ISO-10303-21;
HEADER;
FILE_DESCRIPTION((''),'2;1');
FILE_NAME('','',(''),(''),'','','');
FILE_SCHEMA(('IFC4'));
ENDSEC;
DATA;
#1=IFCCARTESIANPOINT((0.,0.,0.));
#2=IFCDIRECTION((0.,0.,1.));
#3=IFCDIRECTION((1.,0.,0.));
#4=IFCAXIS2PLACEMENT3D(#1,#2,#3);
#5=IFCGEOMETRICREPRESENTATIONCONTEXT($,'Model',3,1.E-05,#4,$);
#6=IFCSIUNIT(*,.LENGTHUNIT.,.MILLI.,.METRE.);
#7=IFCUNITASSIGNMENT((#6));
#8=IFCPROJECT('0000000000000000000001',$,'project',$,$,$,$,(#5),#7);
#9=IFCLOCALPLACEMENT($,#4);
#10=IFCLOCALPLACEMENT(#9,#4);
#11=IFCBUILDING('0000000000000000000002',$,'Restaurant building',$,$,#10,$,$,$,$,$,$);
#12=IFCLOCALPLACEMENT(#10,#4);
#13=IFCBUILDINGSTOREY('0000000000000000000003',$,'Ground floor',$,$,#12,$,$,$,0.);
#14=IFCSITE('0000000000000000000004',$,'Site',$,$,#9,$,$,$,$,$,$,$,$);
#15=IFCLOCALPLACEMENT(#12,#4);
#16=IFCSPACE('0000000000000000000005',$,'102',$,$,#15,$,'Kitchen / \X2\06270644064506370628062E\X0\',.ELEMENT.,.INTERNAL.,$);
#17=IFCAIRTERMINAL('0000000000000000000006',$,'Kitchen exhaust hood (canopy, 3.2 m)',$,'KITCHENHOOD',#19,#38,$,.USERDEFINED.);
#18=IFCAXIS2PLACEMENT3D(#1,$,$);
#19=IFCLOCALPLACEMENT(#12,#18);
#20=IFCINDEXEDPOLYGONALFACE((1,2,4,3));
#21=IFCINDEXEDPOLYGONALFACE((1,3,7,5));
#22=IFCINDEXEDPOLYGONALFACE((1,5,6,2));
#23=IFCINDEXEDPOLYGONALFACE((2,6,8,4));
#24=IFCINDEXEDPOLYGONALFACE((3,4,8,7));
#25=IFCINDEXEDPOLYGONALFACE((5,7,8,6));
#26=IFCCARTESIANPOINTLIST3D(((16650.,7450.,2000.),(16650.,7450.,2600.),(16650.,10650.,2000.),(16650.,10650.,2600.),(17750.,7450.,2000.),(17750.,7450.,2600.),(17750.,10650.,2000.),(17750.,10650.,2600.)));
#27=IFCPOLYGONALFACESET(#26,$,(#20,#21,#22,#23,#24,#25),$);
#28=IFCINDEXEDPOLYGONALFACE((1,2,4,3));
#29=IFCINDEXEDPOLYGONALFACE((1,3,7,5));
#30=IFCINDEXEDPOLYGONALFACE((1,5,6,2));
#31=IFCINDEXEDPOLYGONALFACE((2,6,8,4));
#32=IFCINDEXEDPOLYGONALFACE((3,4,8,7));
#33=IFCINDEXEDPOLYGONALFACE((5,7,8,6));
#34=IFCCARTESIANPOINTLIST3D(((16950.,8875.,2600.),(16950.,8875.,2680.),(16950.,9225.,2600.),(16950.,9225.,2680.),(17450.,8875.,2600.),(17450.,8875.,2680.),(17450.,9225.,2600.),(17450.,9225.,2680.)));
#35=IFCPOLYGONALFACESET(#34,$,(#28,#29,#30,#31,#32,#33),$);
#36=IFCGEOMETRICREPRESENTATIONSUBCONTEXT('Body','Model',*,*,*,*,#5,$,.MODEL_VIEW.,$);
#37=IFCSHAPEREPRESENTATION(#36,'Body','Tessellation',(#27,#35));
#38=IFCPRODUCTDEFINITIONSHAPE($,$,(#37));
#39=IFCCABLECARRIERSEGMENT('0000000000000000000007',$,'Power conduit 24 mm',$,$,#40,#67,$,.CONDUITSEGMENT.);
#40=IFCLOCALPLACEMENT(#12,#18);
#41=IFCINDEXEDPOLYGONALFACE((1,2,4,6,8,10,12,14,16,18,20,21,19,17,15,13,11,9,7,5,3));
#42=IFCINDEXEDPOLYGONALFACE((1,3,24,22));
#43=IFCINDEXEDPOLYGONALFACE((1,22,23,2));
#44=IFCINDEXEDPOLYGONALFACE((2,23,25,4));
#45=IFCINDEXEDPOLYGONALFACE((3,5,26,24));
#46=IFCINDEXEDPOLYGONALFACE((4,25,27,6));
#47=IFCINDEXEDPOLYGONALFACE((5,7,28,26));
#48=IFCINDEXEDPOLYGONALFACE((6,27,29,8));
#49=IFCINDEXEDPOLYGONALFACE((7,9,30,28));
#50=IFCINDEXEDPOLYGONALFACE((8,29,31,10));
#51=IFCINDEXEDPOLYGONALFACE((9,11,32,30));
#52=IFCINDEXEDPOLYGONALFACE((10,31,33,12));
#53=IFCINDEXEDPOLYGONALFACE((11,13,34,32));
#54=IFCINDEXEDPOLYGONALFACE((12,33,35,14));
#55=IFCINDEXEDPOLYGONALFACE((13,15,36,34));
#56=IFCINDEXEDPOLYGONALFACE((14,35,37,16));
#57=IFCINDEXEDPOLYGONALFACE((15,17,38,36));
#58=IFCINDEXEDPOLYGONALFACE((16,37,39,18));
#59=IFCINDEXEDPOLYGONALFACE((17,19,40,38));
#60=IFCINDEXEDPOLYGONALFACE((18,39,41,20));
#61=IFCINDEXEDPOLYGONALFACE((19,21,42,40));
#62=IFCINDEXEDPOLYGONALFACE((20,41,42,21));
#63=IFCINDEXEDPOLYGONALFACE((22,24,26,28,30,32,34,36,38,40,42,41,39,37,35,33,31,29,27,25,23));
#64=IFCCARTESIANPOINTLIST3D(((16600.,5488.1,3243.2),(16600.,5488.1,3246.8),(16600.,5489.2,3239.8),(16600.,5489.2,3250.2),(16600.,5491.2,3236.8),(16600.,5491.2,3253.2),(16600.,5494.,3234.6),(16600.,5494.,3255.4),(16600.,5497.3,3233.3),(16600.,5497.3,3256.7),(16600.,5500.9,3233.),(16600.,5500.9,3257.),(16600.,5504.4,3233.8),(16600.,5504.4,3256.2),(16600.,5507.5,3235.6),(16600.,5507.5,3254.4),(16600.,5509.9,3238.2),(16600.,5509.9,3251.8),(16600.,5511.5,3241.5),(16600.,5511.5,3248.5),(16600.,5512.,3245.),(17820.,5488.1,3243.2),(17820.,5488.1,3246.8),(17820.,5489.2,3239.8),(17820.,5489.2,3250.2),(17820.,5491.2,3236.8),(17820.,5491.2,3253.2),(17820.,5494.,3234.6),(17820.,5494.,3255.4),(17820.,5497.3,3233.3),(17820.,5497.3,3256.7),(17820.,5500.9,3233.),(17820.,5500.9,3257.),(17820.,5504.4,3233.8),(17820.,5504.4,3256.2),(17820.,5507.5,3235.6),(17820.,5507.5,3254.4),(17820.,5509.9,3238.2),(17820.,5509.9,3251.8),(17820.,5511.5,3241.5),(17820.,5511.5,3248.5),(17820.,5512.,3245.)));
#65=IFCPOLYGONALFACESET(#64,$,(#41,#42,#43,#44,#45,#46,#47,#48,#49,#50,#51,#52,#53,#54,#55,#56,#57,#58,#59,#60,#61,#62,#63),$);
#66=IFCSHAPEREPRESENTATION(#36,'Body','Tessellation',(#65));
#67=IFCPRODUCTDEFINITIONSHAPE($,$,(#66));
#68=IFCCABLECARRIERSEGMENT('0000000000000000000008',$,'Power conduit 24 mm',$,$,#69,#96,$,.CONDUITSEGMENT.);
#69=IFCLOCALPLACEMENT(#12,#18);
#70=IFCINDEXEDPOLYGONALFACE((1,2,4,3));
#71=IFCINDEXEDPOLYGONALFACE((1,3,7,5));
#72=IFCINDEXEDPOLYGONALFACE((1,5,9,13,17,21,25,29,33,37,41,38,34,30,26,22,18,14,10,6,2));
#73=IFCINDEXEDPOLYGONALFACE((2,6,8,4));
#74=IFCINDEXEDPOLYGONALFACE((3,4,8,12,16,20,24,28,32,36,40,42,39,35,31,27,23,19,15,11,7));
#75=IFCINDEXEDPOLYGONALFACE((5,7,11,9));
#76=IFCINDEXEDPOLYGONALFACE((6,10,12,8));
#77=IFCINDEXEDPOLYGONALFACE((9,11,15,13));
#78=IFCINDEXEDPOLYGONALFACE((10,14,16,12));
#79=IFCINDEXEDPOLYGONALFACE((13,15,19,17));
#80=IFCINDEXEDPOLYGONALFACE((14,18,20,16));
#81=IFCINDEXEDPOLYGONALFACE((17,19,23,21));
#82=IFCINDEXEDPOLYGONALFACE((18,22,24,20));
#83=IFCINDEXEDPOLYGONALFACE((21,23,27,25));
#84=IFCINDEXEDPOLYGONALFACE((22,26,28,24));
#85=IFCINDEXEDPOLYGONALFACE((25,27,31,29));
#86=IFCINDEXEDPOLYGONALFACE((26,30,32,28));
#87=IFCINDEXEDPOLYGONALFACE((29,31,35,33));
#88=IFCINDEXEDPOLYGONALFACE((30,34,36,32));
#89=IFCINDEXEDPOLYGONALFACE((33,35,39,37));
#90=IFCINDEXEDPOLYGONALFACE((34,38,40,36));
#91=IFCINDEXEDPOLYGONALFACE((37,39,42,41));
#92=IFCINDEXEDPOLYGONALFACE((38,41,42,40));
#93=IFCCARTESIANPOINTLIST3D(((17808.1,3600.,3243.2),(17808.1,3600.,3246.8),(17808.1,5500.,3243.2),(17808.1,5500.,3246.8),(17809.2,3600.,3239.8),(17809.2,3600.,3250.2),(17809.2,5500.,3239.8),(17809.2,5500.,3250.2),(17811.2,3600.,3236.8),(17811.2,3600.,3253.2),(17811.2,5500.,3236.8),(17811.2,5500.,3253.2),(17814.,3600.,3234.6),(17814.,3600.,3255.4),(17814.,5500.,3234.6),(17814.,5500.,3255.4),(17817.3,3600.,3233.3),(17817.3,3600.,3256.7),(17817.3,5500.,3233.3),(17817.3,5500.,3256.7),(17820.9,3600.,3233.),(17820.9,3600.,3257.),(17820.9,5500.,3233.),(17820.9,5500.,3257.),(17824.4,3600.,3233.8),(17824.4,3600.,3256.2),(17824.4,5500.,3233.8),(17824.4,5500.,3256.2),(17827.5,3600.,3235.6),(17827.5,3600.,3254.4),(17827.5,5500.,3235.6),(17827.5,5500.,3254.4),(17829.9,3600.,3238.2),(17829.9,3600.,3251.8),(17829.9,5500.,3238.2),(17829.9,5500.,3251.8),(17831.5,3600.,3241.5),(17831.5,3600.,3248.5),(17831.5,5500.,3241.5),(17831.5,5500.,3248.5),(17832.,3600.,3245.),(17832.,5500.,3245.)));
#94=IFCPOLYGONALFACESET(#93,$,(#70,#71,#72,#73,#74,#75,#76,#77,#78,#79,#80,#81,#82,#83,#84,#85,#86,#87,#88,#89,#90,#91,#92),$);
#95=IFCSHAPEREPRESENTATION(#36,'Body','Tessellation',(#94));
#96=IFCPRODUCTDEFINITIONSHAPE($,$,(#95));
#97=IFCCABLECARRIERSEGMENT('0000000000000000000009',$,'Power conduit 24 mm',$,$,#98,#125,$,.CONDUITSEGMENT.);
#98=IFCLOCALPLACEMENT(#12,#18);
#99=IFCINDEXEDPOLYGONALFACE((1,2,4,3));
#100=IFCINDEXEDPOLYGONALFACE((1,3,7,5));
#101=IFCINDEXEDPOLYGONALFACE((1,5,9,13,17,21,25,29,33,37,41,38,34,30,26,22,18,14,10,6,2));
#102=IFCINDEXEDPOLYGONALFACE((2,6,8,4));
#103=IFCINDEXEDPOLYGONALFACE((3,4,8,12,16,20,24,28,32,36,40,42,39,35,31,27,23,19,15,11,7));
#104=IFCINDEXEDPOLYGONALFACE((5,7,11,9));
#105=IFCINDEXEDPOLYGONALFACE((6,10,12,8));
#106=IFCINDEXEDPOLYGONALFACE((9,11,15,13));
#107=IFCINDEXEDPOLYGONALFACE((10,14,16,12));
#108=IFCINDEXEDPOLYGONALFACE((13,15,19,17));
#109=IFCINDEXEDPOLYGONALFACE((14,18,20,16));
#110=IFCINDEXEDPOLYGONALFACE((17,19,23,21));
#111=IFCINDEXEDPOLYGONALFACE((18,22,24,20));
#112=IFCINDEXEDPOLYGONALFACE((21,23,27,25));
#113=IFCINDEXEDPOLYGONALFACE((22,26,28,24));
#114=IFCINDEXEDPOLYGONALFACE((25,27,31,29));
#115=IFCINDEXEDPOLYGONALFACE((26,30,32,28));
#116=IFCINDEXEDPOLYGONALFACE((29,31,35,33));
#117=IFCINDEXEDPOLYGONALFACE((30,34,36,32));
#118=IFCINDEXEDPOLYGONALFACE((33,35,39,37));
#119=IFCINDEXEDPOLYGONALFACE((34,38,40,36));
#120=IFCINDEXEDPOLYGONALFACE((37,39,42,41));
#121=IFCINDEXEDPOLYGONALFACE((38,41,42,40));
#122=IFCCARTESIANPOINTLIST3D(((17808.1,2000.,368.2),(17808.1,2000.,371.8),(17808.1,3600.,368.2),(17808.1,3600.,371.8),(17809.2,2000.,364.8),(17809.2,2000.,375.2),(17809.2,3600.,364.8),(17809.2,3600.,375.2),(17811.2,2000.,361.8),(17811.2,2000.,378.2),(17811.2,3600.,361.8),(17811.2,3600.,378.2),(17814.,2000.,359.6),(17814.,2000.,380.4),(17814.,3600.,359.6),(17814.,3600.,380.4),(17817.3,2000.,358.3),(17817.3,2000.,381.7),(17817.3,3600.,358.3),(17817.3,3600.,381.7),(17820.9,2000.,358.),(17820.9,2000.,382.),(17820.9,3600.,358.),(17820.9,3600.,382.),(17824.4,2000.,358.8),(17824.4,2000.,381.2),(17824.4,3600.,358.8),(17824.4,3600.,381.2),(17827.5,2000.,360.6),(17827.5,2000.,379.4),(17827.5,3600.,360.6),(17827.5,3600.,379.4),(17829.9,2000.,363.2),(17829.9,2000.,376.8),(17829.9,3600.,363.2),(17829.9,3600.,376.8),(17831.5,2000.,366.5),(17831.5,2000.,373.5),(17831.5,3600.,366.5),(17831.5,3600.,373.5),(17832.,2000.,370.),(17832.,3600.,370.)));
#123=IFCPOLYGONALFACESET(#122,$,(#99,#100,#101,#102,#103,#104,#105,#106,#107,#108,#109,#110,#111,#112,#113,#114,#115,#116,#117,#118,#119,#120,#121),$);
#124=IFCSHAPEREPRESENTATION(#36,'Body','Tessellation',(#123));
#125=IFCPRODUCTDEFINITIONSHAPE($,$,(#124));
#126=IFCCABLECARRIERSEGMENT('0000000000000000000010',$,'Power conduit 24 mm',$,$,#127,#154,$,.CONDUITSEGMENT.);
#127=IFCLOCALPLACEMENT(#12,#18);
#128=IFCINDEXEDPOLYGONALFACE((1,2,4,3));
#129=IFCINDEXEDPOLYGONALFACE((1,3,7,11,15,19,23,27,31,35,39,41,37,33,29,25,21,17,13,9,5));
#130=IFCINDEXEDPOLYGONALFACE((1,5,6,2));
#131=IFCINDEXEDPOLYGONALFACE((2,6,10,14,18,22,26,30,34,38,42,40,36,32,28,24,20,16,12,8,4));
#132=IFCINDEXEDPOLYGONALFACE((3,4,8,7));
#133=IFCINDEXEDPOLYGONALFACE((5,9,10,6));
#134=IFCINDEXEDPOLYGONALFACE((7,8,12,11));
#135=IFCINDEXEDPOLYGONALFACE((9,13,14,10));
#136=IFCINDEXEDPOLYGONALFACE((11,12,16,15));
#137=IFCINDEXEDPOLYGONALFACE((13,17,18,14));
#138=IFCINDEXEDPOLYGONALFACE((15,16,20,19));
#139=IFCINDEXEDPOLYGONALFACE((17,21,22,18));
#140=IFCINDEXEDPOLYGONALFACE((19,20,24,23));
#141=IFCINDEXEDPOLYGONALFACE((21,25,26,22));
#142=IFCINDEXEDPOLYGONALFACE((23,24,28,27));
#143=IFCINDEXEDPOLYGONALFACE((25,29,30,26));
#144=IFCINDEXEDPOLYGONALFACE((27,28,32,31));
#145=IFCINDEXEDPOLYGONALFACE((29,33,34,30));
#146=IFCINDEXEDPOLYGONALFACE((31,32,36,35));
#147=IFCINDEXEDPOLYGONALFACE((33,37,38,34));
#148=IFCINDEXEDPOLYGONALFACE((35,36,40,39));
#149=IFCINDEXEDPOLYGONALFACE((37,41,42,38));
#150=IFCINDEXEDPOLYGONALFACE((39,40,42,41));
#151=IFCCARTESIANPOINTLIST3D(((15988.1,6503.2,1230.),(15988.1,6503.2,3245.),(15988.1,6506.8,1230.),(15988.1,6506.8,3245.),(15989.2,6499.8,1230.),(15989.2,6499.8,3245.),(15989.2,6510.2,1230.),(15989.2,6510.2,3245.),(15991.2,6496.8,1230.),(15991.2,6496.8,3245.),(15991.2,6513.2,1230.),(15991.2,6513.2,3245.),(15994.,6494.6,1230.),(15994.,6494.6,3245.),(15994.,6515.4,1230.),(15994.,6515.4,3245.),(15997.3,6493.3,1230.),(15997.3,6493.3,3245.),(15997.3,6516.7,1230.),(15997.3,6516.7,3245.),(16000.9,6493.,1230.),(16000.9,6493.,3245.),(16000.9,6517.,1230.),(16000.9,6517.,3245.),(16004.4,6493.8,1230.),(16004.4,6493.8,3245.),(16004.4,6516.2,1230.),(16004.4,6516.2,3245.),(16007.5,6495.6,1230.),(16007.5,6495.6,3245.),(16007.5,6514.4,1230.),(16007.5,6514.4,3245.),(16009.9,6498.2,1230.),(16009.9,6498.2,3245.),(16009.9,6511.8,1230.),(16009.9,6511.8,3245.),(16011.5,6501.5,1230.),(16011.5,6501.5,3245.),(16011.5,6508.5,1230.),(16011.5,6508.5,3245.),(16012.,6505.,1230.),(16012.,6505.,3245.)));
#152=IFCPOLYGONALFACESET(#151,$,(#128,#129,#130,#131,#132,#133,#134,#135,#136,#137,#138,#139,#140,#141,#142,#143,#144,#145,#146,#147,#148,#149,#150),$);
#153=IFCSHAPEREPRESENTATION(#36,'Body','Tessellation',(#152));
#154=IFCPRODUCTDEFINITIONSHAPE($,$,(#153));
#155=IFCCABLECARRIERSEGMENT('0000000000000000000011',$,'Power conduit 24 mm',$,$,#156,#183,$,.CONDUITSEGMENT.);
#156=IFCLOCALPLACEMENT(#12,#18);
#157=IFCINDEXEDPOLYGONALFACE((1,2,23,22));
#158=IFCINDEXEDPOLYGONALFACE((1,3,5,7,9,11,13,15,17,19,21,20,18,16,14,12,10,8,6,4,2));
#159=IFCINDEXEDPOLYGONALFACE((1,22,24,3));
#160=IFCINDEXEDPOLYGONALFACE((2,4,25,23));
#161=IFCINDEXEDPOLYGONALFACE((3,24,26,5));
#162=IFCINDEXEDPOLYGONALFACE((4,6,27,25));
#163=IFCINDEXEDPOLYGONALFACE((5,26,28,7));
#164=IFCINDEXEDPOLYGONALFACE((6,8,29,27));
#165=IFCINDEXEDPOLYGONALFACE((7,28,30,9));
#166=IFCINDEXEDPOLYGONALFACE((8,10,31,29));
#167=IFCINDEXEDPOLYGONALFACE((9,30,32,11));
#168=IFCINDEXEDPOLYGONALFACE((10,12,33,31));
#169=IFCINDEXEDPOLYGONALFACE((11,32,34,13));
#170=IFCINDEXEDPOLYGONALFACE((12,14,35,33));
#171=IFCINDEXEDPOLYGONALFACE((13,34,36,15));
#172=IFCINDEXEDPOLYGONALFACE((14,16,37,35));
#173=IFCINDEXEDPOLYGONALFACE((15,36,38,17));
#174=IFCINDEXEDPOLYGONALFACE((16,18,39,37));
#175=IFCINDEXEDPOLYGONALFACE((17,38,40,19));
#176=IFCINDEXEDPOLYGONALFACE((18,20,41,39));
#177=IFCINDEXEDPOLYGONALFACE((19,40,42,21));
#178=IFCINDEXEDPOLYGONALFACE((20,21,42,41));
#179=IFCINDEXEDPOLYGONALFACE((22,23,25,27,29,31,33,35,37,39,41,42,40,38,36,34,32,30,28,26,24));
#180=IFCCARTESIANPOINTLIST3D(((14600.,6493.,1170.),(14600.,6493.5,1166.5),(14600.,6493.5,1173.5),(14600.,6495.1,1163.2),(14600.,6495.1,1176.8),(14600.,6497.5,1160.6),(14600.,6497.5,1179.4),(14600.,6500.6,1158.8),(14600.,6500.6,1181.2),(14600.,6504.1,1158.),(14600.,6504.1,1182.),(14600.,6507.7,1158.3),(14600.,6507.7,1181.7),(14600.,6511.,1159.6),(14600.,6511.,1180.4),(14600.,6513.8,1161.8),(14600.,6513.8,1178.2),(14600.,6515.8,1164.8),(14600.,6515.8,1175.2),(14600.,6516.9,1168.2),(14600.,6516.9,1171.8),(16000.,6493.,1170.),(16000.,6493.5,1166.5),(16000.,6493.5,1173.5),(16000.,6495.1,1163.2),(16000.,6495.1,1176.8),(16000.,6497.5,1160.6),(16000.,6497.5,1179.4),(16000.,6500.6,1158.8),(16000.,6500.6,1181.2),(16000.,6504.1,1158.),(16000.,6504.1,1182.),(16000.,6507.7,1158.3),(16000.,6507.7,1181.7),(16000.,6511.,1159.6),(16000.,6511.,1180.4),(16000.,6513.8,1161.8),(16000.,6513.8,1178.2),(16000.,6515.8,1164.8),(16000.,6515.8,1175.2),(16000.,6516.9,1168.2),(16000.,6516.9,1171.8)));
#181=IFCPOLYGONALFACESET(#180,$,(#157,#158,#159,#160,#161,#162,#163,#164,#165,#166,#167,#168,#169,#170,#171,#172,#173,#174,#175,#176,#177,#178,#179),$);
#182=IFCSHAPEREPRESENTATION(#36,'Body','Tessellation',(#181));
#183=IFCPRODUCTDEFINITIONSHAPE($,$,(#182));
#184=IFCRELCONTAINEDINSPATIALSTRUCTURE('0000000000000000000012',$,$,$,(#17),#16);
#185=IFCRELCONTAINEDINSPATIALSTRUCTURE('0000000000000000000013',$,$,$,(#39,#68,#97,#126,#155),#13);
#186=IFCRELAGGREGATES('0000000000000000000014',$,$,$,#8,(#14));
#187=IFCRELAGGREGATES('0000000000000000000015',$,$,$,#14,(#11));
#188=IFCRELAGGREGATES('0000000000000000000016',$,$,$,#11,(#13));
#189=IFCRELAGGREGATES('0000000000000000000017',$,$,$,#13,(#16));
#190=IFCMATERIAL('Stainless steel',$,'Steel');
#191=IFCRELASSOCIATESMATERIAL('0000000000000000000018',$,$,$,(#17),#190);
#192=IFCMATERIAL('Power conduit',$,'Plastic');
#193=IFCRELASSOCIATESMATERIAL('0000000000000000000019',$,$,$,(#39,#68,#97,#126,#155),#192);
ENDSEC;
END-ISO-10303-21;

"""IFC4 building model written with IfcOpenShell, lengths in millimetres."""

from ifc_helpers import new_model, si_unit, frame, origin_with_axes, origin_2d, place, context, subcontext, project, spatial, rectangle, circle, extrude, material, element, save


model = new_model("IFC4")

# Units and contexts
model_context = context("Model", 3, precision=1e-05, world=origin_with_axes())
body_context = subcontext(model_context, "Body", "Model", "MODEL_VIEW")
ifc_project = project(units=[si_unit("LENGTHUNIT", "METRE", prefix="MILLI")], contexts=[model_context])

# Site, building, storey
site_placement = place(None, origin_with_axes())
site = spatial("IfcSite", under=ifc_project, at=site_placement, Name="Site")
building_placement = place(site_placement, origin_with_axes())
building = spatial("IfcBuilding", under=site, at=building_placement, Name="Restaurant building")
storey_placement = place(building_placement, origin_with_axes())
storey = spatial("IfcBuildingStorey", under=building, at=storey_placement, Name="Ground floor", Elevation=0.0)

# Shared definitions
space_1_placement = place(storey_placement, origin_with_axes())
space_1 = spatial("IfcSpace", under=storey, at=space_1_placement, Name="102", LongName="Kitchen / المطبخ", CompositionType="ELEMENT", PredefinedType="INTERNAL")

# Air terminal
ifc_material_1 = material(Name="Stainless steel", Category="Steel")
air_terminal_placement = place(storey_placement, frame((16650.0, 7450.0, 0.0)))
element("IfcAirTerminal", 1, at=air_terminal_placement, inside=space_1, material=ifc_material_1, Name="Kitchen exhaust hood (canopy, 3.2 m)", ObjectType="KITCHENHOOD", PredefinedType="USERDEFINED", context=body_context, shape_type="SweptSolid", body=[
    extrude(rectangle(XDim=1100.0, YDim=3200.0, at=origin_2d()), frame((550.0, 1600.0, 2000.0)), (0.0, 0.0, 1.0), 600.0),
    extrude(rectangle(XDim=500.0, YDim=350.0, at=origin_2d()), frame((550.0, 1600.0, 2600.0)), (0.0, 0.0, 1.0), 80.0),
])

# Cable carrier segments
ifc_material_2 = material(Name="Power conduit", Category="Plastic")
cable_carrier_segment_1_placement = place(storey_placement, frame((16600.0, 5500.0, 3245.0)))
element("IfcCableCarrierSegment", 2, at=cable_carrier_segment_1_placement, inside=storey, material=ifc_material_2, Name="Power conduit 24 mm", PredefinedType="CONDUITSEGMENT", context=body_context, shape_type="SweptSolid", body=[
    extrude(circle(Radius=12.0, at=origin_2d()), frame((0.0, 0.0, 0.0), z_axis=(1.0, 0.0, 0.0), x_axis=(0.0, 1.0, 0.0)), (0.0, 0.0, 1.0), 1220.0),
])
cable_carrier_segment_2_placement = place(storey_placement, frame((17820.0, 5500.0, 3245.0)))
element("IfcCableCarrierSegment", 3, at=cable_carrier_segment_2_placement, inside=storey, material=ifc_material_2, Name="Power conduit 24 mm", PredefinedType="CONDUITSEGMENT", context=body_context, shape_type="SweptSolid", body=[
    extrude(circle(Radius=12.0, at=origin_2d()), frame((0.0, 0.0, 0.0), z_axis=(0.0, -1.0, 0.0), x_axis=(1.0, 0.0, 0.0)), (0.0, 0.0, 1.0), 1900.0),
])
cable_carrier_segment_3_placement = place(storey_placement, frame((17820.0, 3600.0, 370.0)))
element("IfcCableCarrierSegment", 4, at=cable_carrier_segment_3_placement, inside=storey, material=ifc_material_2, Name="Power conduit 24 mm", PredefinedType="CONDUITSEGMENT", context=body_context, shape_type="SweptSolid", body=[
    extrude(circle(Radius=12.0, at=origin_2d()), frame((0.0, 0.0, 0.0), z_axis=(0.0, -1.0, 0.0), x_axis=(1.0, 0.0, 0.0)), (0.0, 0.0, 1.0), 1600.0),
])
cable_carrier_segment_4_placement = place(storey_placement, frame((16000.0, 6505.0, 3245.0)))
element("IfcCableCarrierSegment", 5, at=cable_carrier_segment_4_placement, inside=storey, material=ifc_material_2, Name="Power conduit 24 mm", PredefinedType="CONDUITSEGMENT", context=body_context, shape_type="SweptSolid", body=[
    extrude(circle(Radius=12.0, at=origin_2d()), frame((0.0, 0.0, 0.0), z_axis=(0.0, 0.0, -1.0), x_axis=(1.0, 0.0, 0.0)), (0.0, 0.0, 1.0), 2015.0),
])
cable_carrier_segment_5_placement = place(storey_placement, frame((16000.0, 6505.0, 1170.0)))
element("IfcCableCarrierSegment", 6, at=cable_carrier_segment_5_placement, inside=storey, material=ifc_material_2, Name="Power conduit 24 mm", PredefinedType="CONDUITSEGMENT", context=body_context, shape_type="SweptSolid", body=[
    extrude(circle(Radius=12.0, at=origin_2d()), frame((0.0, 0.0, 0.0), z_axis=(-1.0, 0.0, 0.0), x_axis=(0.0, -1.0, 0.0)), (0.0, 0.0, 1.0), 1400.0),
])

save(model, "model.ifc")
